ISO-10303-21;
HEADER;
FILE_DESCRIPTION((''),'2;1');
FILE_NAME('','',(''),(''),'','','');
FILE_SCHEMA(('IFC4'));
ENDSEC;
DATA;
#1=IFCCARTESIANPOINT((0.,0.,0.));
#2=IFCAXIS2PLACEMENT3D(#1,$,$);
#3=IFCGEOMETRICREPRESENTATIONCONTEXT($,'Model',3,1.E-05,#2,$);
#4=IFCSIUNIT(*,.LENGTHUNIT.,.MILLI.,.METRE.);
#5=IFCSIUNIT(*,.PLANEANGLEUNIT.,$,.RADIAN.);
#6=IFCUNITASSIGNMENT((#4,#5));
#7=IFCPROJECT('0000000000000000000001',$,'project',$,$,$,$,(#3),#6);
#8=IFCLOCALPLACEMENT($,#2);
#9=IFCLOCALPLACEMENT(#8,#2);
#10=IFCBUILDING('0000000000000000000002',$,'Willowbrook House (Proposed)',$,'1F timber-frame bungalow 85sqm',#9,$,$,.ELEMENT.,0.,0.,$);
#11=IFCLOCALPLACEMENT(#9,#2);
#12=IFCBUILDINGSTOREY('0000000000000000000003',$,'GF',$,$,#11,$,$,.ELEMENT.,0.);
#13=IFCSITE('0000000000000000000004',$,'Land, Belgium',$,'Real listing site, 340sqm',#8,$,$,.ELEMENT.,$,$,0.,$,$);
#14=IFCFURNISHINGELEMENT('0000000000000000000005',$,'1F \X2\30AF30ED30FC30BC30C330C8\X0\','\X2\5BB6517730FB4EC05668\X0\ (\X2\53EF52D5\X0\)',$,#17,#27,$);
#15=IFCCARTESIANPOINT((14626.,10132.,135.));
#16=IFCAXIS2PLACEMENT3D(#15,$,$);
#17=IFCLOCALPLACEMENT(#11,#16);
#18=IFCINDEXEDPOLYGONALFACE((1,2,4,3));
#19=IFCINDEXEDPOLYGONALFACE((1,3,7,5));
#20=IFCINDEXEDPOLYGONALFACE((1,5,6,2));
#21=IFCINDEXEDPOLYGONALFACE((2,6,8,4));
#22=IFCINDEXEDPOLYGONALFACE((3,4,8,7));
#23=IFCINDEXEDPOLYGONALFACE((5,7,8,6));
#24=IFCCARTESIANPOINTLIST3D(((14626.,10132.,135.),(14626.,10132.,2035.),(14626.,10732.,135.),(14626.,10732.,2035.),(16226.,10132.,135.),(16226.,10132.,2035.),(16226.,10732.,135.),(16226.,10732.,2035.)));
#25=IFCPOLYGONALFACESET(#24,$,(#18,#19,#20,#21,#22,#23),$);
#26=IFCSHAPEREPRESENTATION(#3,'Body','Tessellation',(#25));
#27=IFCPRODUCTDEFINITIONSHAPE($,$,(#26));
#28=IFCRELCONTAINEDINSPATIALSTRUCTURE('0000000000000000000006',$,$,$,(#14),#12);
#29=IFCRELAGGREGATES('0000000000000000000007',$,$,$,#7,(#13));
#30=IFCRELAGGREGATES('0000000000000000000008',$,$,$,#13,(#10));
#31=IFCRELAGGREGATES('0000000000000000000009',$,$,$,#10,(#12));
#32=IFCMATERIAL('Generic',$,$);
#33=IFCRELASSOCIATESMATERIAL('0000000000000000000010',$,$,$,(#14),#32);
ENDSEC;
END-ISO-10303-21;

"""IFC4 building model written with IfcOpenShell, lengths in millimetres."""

from ifc_helpers import new_model, si_unit, frame, frame_2d, origin, place, context, project, spatial, rectangle, extrude, material, element, save


model = new_model("IFC4")

# Units and contexts
model_context = context("Model", 3, precision=1e-05, world=origin())
ifc_project = project(units=[si_unit("LENGTHUNIT", "METRE", prefix="MILLI"), si_unit("PLANEANGLEUNIT", "RADIAN")], contexts=[model_context])

# Site, building, storey
site_placement = place(None, origin())
site = spatial("IfcSite", under=ifc_project, at=site_placement, Name="Land, Belgium", ObjectType="Real listing site, 340sqm", CompositionType="ELEMENT", RefElevation=0.0)
building_placement = place(site_placement, origin())
building = spatial("IfcBuilding", under=site, at=building_placement, Name="Willowbrook House (Proposed)", ObjectType="1F timber-frame bungalow 85sqm", CompositionType="ELEMENT", ElevationOfRefHeight=0.0, ElevationOfTerrain=0.0)
storey_placement = place(building_placement, origin())
storey = spatial("IfcBuildingStorey", under=building, at=storey_placement, Name="GF", CompositionType="ELEMENT", Elevation=0.0)

# Shared definitions
ifc_material_1 = material(Name="Generic")

# Furnishing element
furnishing_placement = place(storey_placement, frame((14626.0, 10132.0, 135.0)))
element("IfcFurnishingElement", 1, at=furnishing_placement, inside=storey, material=ifc_material_1, Name="1F クローゼット", Description="家具・什器 (可動)", context=model_context, shape_type="SweptSolid", body=[
    extrude(rectangle(XDim=1600.0, YDim=600.0, at=frame_2d((800.0, 300.0))), frame((14626.0, 10132.0, 135.0)), (0.0, 0.0, 1.0), 1900.0),
])

save(model, "model.ifc")
